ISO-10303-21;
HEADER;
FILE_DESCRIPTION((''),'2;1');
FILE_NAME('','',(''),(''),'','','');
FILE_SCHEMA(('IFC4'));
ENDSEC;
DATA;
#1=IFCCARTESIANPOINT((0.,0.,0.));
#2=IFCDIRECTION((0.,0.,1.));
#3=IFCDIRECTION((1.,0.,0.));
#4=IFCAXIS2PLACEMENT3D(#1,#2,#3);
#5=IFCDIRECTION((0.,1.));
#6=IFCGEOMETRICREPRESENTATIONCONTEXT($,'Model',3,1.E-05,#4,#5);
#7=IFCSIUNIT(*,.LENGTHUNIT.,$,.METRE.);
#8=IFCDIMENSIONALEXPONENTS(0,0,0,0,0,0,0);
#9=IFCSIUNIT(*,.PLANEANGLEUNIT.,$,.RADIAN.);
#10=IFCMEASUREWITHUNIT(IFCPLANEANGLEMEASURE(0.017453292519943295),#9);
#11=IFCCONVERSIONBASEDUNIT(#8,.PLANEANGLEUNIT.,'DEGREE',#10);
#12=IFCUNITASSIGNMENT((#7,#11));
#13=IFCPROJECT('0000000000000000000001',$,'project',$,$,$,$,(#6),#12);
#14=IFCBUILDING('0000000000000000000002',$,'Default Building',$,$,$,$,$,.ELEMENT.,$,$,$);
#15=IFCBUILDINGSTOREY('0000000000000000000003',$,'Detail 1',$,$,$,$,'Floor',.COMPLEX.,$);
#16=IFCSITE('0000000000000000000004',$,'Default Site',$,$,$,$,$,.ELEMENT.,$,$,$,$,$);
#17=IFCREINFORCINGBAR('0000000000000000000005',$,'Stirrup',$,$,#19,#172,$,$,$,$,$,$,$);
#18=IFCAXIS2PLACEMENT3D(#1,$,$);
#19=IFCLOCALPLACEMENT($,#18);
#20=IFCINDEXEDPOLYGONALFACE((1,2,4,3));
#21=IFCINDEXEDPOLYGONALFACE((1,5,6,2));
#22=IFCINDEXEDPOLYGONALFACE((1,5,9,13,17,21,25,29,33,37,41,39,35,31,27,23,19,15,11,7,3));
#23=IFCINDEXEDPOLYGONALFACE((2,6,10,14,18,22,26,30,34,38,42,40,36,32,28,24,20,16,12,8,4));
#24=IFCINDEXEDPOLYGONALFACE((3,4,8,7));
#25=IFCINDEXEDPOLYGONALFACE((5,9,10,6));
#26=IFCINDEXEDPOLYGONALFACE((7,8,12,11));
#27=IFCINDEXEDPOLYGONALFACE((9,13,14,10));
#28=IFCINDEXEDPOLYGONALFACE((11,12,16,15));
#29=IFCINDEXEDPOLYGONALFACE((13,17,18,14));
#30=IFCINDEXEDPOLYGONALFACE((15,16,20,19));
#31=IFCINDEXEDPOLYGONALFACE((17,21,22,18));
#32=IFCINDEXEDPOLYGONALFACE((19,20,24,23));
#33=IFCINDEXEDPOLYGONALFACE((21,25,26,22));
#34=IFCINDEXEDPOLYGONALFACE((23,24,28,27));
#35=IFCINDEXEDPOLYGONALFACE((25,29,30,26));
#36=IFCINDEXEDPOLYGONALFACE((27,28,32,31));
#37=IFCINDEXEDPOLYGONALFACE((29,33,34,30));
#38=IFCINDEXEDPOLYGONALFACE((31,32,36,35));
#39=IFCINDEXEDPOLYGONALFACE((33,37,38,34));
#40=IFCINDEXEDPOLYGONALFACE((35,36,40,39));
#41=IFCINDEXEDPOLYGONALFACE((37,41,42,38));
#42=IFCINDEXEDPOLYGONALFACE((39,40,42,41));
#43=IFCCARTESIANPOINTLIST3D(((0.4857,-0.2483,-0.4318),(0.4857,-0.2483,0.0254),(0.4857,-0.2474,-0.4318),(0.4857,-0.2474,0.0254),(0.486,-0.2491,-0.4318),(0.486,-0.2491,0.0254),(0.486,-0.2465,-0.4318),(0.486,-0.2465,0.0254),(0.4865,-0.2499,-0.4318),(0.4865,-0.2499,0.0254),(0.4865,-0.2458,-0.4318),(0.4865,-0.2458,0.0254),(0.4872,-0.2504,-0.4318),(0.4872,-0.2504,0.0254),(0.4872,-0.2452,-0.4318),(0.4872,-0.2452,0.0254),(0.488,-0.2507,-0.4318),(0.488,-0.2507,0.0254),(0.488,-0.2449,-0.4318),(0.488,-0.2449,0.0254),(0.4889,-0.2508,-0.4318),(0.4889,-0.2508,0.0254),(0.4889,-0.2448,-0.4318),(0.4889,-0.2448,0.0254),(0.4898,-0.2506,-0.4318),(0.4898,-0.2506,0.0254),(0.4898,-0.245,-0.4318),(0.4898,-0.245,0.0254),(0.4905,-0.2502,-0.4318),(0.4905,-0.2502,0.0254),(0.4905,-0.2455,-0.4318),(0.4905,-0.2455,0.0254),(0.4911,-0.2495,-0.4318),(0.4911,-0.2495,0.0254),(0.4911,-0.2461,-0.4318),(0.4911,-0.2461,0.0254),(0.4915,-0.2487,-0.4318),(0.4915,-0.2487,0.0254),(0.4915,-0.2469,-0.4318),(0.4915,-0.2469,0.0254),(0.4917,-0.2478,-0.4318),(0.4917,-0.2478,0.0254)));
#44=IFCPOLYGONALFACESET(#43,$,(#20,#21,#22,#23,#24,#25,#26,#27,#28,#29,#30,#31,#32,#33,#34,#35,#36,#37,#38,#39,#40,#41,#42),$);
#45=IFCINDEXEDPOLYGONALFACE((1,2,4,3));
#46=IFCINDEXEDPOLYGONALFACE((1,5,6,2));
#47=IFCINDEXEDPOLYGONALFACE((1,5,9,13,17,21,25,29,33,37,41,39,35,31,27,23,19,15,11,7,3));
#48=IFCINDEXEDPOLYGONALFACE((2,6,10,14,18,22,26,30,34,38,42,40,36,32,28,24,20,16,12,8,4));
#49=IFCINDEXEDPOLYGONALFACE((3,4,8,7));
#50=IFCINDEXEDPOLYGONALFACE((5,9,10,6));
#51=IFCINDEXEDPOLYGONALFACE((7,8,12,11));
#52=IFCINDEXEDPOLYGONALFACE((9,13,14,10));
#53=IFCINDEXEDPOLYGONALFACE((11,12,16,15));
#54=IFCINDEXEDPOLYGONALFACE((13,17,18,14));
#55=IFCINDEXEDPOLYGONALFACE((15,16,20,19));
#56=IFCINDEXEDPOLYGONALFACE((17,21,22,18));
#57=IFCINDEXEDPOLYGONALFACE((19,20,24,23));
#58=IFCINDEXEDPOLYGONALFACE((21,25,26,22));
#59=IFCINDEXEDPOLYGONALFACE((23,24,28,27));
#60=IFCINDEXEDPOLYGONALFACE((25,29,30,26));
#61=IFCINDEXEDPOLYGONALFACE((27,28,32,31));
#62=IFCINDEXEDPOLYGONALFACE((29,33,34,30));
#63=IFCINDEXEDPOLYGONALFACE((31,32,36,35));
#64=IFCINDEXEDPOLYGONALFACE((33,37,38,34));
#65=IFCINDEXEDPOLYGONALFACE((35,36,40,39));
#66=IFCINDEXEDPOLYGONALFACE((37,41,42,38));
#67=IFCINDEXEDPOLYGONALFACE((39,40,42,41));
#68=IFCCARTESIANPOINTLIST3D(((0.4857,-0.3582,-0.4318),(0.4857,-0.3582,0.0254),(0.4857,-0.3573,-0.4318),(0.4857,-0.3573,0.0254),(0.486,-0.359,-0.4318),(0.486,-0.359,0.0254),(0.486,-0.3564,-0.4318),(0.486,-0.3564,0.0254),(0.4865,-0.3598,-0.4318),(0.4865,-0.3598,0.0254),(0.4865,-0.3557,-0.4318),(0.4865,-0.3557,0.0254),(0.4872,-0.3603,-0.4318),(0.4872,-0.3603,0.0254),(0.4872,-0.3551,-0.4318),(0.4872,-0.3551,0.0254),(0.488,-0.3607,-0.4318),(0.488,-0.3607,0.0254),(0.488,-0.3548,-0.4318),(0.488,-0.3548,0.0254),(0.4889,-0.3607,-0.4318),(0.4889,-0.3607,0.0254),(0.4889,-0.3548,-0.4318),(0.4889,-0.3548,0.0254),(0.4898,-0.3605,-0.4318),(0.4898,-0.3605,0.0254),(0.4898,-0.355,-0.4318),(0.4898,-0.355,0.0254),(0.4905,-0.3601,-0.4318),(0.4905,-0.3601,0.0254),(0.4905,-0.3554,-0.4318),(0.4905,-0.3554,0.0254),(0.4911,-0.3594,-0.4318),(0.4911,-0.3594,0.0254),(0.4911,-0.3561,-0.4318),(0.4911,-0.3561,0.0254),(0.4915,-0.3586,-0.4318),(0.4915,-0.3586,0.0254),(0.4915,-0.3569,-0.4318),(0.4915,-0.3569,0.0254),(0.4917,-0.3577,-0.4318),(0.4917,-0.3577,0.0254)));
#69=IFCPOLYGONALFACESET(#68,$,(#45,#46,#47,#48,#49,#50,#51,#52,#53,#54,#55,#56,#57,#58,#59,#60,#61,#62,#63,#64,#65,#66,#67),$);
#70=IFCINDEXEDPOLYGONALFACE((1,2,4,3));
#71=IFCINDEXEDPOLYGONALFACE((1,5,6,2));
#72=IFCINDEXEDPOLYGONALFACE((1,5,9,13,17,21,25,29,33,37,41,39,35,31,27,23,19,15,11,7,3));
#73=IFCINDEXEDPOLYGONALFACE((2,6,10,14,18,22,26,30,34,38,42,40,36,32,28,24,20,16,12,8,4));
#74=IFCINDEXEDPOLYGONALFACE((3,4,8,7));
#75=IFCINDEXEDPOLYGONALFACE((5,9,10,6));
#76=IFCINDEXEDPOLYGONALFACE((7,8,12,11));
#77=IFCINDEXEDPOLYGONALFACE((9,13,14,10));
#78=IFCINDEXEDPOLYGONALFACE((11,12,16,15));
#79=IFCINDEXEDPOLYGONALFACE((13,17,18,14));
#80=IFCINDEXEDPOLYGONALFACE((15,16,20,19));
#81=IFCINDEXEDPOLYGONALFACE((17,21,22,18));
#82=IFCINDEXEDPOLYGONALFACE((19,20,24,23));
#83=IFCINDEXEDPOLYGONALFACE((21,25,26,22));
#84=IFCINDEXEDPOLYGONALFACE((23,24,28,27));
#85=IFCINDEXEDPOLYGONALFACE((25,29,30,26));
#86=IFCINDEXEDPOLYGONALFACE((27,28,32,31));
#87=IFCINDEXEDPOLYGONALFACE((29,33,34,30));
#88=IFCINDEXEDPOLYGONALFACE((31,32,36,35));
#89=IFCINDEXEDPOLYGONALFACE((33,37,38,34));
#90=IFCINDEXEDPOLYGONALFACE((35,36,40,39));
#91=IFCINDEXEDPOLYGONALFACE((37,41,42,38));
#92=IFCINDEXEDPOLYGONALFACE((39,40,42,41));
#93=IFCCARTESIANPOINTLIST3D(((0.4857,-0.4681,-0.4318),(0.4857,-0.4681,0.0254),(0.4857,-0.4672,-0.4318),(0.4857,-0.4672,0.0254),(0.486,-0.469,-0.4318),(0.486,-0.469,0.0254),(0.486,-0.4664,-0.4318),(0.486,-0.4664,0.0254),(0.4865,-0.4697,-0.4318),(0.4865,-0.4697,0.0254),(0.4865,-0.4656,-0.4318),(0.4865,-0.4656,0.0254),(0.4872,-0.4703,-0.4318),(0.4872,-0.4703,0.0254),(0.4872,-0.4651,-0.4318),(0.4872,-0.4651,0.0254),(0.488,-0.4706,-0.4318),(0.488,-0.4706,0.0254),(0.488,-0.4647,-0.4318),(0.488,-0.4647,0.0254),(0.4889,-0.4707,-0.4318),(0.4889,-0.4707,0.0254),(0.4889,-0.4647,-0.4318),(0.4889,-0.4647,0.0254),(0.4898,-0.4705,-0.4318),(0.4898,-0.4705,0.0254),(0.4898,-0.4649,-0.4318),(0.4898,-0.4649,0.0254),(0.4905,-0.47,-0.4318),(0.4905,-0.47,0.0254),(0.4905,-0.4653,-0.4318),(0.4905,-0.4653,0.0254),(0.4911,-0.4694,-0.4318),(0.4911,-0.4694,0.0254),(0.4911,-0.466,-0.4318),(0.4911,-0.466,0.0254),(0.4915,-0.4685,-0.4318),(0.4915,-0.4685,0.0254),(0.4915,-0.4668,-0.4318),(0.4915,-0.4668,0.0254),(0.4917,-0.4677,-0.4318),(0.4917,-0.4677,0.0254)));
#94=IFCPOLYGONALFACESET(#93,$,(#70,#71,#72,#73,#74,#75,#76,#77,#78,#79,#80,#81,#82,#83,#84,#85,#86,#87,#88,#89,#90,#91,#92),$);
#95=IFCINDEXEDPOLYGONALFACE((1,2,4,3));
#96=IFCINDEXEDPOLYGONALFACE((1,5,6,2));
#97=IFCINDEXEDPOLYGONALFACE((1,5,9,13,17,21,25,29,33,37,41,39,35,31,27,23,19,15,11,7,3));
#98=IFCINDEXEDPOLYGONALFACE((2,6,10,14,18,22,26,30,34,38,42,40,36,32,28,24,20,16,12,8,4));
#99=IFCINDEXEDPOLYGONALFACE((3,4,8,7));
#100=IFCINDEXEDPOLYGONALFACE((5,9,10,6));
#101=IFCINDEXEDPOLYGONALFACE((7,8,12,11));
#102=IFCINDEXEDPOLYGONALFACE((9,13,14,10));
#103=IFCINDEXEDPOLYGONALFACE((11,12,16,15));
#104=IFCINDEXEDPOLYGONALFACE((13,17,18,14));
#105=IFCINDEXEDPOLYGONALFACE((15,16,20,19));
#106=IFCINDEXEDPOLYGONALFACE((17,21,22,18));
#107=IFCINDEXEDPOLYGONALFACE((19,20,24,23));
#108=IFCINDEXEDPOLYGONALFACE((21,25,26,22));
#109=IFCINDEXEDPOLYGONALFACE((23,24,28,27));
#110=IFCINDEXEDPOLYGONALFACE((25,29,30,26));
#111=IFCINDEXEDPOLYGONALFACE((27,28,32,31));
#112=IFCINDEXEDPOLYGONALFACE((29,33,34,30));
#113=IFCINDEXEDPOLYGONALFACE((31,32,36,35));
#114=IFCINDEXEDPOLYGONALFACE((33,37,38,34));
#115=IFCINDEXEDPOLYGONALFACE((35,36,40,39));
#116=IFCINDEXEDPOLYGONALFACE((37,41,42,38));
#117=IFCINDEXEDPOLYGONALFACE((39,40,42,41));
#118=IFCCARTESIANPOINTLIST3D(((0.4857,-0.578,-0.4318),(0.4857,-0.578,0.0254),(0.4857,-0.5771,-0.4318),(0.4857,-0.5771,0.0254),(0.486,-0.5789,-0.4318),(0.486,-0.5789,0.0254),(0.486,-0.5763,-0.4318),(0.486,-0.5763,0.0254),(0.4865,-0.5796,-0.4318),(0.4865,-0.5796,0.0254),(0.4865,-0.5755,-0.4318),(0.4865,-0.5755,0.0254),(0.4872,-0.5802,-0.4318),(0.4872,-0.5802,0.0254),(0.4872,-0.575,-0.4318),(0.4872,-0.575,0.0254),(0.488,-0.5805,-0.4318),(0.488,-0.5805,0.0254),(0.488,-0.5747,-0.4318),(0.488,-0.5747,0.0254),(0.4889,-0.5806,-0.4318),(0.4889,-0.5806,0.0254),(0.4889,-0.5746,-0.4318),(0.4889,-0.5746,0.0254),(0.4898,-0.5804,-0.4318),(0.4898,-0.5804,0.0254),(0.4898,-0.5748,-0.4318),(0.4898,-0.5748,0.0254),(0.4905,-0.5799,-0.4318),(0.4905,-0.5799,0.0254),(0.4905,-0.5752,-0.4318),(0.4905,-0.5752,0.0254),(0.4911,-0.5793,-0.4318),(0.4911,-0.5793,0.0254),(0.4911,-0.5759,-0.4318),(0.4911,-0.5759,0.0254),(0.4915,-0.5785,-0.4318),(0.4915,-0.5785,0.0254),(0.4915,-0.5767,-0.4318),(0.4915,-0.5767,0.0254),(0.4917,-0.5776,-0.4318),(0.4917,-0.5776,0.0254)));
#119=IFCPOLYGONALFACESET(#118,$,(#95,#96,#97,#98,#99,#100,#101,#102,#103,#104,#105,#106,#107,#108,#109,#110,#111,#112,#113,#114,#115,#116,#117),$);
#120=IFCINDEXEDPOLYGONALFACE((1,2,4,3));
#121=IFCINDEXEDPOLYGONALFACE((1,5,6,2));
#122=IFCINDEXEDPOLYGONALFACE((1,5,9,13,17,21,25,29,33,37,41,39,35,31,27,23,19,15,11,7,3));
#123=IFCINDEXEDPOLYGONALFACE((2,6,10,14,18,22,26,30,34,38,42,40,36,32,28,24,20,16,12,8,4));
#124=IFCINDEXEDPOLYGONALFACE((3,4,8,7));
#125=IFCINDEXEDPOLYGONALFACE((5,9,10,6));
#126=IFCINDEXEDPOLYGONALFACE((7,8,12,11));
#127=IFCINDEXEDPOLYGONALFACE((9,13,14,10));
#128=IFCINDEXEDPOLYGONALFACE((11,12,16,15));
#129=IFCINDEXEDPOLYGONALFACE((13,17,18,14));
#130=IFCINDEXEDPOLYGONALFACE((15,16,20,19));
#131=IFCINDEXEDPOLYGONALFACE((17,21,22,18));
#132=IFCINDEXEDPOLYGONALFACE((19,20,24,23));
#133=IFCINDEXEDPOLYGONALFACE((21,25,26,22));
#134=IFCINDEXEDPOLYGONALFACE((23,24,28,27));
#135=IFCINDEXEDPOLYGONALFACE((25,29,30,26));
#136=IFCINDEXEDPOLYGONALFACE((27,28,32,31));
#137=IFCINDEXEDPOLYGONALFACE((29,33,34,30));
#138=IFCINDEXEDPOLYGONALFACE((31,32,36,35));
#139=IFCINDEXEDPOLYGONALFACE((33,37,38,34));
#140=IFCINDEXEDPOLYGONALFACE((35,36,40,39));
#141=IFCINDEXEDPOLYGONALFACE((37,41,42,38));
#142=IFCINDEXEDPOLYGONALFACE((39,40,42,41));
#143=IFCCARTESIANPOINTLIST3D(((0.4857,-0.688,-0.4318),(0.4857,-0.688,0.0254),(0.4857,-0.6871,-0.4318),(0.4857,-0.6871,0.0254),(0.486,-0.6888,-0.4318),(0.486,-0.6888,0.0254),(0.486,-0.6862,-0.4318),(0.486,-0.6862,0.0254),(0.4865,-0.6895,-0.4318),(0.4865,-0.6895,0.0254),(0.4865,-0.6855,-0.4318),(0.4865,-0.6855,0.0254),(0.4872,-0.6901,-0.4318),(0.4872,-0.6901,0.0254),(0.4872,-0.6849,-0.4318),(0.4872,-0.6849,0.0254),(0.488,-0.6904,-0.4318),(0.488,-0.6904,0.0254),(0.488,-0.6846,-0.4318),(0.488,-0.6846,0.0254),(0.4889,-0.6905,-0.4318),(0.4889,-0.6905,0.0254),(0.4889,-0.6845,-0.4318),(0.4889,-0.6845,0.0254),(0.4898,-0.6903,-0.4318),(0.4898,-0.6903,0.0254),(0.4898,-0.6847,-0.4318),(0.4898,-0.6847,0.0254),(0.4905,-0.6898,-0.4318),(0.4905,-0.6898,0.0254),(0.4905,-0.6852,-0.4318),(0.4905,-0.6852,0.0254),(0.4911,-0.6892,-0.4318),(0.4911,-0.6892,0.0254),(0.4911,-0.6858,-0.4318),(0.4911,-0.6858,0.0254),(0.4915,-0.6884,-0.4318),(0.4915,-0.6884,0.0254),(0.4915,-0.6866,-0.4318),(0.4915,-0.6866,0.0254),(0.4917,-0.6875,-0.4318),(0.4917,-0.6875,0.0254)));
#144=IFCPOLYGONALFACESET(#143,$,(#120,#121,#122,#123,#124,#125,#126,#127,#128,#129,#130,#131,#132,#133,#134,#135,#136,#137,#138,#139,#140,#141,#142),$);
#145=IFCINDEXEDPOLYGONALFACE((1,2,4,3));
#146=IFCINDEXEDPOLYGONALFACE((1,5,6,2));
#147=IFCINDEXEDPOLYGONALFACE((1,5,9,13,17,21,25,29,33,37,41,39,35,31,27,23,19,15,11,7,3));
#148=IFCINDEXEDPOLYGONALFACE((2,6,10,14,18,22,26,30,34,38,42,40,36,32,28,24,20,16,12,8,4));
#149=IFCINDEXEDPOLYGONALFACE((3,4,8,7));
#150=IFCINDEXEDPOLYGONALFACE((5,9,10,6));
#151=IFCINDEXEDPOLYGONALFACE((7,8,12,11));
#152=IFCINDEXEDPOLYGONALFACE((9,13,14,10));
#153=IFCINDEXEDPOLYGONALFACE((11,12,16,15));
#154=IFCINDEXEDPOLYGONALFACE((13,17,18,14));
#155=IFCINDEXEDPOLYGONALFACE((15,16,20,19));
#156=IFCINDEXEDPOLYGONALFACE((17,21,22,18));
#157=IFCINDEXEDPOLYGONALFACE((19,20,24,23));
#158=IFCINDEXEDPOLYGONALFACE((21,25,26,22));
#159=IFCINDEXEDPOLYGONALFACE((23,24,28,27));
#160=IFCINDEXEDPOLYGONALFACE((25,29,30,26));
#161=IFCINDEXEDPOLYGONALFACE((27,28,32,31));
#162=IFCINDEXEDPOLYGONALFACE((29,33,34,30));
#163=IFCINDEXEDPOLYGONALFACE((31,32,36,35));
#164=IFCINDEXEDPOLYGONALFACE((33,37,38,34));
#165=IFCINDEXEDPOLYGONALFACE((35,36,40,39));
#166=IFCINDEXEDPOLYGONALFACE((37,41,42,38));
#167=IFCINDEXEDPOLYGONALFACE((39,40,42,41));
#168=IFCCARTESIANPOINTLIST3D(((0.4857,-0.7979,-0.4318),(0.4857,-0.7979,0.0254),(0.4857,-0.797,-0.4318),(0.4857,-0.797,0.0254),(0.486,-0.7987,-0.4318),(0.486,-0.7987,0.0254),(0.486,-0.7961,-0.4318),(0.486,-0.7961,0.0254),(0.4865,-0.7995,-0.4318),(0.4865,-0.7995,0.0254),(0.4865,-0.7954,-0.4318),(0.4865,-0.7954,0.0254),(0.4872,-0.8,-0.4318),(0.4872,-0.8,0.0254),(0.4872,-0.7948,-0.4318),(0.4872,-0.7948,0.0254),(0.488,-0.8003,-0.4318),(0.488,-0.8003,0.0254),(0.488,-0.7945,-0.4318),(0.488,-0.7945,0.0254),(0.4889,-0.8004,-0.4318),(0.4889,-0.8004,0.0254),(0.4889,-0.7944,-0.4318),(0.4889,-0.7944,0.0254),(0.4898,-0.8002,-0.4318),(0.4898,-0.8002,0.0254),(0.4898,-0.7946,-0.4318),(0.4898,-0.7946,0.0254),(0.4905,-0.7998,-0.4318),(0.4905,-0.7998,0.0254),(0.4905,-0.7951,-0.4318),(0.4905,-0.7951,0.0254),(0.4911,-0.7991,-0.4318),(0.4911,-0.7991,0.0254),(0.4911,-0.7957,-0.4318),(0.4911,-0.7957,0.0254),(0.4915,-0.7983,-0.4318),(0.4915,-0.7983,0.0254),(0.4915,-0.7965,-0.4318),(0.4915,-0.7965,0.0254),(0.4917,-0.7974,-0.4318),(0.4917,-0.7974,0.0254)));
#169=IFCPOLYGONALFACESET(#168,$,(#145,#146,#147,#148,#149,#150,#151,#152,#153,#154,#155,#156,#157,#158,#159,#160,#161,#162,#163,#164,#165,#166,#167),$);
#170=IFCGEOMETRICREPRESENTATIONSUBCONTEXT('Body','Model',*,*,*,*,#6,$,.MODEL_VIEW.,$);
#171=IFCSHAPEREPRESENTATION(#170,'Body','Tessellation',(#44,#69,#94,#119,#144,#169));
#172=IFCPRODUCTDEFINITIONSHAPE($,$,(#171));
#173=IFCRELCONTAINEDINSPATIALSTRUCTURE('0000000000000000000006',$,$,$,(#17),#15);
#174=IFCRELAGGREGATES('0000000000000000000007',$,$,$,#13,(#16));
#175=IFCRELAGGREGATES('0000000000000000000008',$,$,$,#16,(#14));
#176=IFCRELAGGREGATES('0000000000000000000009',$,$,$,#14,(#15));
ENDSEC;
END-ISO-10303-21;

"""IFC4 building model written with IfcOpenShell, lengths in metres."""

from ifc_helpers import new_model, entity, si_unit, converted_unit, direction, origin_with_axes, place, context, subcontext, project, spatial, element, save


model = new_model("IFC4")

# Units and contexts
model_context = context("Model", 3, precision=1e-05, world=origin_with_axes(), true_north=direction((0.0, 1.0)))
body_context = subcontext(model_context, "Body", "Model", "MODEL_VIEW")
ifc_project = project(units=[si_unit("LENGTHUNIT", "METRE"), converted_unit("PLANEANGLEUNIT", "DEGREE", entity("IfcPlaneAngleMeasure", 0.017453292519943295), si_unit("PLANEANGLEUNIT", "RADIAN"), dimensions=[0, 0, 0, 0, 0, 0, 0])], contexts=[model_context])

# Site, building, storey
site = spatial("IfcSite", under=ifc_project, Name="Default Site", CompositionType="ELEMENT")
building = spatial("IfcBuilding", under=site, Name="Default Building", CompositionType="ELEMENT")
storey = spatial("IfcBuildingStorey", under=building, Name="Detail 1", LongName="Floor", CompositionType="COMPLEX")

# Shared definitions
placement = place(None, origin_with_axes())

# Reinforcing bar
element("IfcReinforcingBar", 1, at=placement, inside=storey, Name="Stirrup", context=body_context, shape_type="SweptSolid", body=[
    entity("IfcSweptDiskSolid", entity("IfcCompositeCurve", [entity("IfcCompositeCurveSegment", "CONTINUOUS", True, entity("IfcPolyline", [entity("IfcCartesianPoint", [0.4887, -0.2478, -0.4318]), entity("IfcCartesianPoint", [0.4887, -0.2478, 0.0254])]))], False), 0.003),
    entity("IfcSweptDiskSolid", entity("IfcCompositeCurve", [entity("IfcCompositeCurveSegment", "CONTINUOUS", True, entity("IfcPolyline", [entity("IfcCartesianPoint", [0.4887, -0.3577, -0.4318]), entity("IfcCartesianPoint", [0.4887, -0.3577, 0.0254])]))], False), 0.003),
    entity("IfcSweptDiskSolid", entity("IfcCompositeCurve", [entity("IfcCompositeCurveSegment", "CONTINUOUS", True, entity("IfcPolyline", [entity("IfcCartesianPoint", [0.4887, -0.4677, -0.4318]), entity("IfcCartesianPoint", [0.4887, -0.4677, 0.0254])]))], False), 0.003),
    entity("IfcSweptDiskSolid", entity("IfcCompositeCurve", [entity("IfcCompositeCurveSegment", "CONTINUOUS", True, entity("IfcPolyline", [entity("IfcCartesianPoint", [0.4887, -0.5776, -0.4318]), entity("IfcCartesianPoint", [0.4887, -0.5776, 0.0254])]))], False), 0.003),
    entity("IfcSweptDiskSolid", entity("IfcCompositeCurve", [entity("IfcCompositeCurveSegment", "CONTINUOUS", True, entity("IfcPolyline", [entity("IfcCartesianPoint", [0.4887, -0.6875, -0.4318]), entity("IfcCartesianPoint", [0.4887, -0.6875, 0.0254])]))], False), 0.003),
    entity("IfcSweptDiskSolid", entity("IfcCompositeCurve", [entity("IfcCompositeCurveSegment", "CONTINUOUS", True, entity("IfcPolyline", [entity("IfcCartesianPoint", [0.4887, -0.7974, -0.4318]), entity("IfcCartesianPoint", [0.4887, -0.7974, 0.0254])]))], False), 0.003),
])

save(model, "model.ifc")
